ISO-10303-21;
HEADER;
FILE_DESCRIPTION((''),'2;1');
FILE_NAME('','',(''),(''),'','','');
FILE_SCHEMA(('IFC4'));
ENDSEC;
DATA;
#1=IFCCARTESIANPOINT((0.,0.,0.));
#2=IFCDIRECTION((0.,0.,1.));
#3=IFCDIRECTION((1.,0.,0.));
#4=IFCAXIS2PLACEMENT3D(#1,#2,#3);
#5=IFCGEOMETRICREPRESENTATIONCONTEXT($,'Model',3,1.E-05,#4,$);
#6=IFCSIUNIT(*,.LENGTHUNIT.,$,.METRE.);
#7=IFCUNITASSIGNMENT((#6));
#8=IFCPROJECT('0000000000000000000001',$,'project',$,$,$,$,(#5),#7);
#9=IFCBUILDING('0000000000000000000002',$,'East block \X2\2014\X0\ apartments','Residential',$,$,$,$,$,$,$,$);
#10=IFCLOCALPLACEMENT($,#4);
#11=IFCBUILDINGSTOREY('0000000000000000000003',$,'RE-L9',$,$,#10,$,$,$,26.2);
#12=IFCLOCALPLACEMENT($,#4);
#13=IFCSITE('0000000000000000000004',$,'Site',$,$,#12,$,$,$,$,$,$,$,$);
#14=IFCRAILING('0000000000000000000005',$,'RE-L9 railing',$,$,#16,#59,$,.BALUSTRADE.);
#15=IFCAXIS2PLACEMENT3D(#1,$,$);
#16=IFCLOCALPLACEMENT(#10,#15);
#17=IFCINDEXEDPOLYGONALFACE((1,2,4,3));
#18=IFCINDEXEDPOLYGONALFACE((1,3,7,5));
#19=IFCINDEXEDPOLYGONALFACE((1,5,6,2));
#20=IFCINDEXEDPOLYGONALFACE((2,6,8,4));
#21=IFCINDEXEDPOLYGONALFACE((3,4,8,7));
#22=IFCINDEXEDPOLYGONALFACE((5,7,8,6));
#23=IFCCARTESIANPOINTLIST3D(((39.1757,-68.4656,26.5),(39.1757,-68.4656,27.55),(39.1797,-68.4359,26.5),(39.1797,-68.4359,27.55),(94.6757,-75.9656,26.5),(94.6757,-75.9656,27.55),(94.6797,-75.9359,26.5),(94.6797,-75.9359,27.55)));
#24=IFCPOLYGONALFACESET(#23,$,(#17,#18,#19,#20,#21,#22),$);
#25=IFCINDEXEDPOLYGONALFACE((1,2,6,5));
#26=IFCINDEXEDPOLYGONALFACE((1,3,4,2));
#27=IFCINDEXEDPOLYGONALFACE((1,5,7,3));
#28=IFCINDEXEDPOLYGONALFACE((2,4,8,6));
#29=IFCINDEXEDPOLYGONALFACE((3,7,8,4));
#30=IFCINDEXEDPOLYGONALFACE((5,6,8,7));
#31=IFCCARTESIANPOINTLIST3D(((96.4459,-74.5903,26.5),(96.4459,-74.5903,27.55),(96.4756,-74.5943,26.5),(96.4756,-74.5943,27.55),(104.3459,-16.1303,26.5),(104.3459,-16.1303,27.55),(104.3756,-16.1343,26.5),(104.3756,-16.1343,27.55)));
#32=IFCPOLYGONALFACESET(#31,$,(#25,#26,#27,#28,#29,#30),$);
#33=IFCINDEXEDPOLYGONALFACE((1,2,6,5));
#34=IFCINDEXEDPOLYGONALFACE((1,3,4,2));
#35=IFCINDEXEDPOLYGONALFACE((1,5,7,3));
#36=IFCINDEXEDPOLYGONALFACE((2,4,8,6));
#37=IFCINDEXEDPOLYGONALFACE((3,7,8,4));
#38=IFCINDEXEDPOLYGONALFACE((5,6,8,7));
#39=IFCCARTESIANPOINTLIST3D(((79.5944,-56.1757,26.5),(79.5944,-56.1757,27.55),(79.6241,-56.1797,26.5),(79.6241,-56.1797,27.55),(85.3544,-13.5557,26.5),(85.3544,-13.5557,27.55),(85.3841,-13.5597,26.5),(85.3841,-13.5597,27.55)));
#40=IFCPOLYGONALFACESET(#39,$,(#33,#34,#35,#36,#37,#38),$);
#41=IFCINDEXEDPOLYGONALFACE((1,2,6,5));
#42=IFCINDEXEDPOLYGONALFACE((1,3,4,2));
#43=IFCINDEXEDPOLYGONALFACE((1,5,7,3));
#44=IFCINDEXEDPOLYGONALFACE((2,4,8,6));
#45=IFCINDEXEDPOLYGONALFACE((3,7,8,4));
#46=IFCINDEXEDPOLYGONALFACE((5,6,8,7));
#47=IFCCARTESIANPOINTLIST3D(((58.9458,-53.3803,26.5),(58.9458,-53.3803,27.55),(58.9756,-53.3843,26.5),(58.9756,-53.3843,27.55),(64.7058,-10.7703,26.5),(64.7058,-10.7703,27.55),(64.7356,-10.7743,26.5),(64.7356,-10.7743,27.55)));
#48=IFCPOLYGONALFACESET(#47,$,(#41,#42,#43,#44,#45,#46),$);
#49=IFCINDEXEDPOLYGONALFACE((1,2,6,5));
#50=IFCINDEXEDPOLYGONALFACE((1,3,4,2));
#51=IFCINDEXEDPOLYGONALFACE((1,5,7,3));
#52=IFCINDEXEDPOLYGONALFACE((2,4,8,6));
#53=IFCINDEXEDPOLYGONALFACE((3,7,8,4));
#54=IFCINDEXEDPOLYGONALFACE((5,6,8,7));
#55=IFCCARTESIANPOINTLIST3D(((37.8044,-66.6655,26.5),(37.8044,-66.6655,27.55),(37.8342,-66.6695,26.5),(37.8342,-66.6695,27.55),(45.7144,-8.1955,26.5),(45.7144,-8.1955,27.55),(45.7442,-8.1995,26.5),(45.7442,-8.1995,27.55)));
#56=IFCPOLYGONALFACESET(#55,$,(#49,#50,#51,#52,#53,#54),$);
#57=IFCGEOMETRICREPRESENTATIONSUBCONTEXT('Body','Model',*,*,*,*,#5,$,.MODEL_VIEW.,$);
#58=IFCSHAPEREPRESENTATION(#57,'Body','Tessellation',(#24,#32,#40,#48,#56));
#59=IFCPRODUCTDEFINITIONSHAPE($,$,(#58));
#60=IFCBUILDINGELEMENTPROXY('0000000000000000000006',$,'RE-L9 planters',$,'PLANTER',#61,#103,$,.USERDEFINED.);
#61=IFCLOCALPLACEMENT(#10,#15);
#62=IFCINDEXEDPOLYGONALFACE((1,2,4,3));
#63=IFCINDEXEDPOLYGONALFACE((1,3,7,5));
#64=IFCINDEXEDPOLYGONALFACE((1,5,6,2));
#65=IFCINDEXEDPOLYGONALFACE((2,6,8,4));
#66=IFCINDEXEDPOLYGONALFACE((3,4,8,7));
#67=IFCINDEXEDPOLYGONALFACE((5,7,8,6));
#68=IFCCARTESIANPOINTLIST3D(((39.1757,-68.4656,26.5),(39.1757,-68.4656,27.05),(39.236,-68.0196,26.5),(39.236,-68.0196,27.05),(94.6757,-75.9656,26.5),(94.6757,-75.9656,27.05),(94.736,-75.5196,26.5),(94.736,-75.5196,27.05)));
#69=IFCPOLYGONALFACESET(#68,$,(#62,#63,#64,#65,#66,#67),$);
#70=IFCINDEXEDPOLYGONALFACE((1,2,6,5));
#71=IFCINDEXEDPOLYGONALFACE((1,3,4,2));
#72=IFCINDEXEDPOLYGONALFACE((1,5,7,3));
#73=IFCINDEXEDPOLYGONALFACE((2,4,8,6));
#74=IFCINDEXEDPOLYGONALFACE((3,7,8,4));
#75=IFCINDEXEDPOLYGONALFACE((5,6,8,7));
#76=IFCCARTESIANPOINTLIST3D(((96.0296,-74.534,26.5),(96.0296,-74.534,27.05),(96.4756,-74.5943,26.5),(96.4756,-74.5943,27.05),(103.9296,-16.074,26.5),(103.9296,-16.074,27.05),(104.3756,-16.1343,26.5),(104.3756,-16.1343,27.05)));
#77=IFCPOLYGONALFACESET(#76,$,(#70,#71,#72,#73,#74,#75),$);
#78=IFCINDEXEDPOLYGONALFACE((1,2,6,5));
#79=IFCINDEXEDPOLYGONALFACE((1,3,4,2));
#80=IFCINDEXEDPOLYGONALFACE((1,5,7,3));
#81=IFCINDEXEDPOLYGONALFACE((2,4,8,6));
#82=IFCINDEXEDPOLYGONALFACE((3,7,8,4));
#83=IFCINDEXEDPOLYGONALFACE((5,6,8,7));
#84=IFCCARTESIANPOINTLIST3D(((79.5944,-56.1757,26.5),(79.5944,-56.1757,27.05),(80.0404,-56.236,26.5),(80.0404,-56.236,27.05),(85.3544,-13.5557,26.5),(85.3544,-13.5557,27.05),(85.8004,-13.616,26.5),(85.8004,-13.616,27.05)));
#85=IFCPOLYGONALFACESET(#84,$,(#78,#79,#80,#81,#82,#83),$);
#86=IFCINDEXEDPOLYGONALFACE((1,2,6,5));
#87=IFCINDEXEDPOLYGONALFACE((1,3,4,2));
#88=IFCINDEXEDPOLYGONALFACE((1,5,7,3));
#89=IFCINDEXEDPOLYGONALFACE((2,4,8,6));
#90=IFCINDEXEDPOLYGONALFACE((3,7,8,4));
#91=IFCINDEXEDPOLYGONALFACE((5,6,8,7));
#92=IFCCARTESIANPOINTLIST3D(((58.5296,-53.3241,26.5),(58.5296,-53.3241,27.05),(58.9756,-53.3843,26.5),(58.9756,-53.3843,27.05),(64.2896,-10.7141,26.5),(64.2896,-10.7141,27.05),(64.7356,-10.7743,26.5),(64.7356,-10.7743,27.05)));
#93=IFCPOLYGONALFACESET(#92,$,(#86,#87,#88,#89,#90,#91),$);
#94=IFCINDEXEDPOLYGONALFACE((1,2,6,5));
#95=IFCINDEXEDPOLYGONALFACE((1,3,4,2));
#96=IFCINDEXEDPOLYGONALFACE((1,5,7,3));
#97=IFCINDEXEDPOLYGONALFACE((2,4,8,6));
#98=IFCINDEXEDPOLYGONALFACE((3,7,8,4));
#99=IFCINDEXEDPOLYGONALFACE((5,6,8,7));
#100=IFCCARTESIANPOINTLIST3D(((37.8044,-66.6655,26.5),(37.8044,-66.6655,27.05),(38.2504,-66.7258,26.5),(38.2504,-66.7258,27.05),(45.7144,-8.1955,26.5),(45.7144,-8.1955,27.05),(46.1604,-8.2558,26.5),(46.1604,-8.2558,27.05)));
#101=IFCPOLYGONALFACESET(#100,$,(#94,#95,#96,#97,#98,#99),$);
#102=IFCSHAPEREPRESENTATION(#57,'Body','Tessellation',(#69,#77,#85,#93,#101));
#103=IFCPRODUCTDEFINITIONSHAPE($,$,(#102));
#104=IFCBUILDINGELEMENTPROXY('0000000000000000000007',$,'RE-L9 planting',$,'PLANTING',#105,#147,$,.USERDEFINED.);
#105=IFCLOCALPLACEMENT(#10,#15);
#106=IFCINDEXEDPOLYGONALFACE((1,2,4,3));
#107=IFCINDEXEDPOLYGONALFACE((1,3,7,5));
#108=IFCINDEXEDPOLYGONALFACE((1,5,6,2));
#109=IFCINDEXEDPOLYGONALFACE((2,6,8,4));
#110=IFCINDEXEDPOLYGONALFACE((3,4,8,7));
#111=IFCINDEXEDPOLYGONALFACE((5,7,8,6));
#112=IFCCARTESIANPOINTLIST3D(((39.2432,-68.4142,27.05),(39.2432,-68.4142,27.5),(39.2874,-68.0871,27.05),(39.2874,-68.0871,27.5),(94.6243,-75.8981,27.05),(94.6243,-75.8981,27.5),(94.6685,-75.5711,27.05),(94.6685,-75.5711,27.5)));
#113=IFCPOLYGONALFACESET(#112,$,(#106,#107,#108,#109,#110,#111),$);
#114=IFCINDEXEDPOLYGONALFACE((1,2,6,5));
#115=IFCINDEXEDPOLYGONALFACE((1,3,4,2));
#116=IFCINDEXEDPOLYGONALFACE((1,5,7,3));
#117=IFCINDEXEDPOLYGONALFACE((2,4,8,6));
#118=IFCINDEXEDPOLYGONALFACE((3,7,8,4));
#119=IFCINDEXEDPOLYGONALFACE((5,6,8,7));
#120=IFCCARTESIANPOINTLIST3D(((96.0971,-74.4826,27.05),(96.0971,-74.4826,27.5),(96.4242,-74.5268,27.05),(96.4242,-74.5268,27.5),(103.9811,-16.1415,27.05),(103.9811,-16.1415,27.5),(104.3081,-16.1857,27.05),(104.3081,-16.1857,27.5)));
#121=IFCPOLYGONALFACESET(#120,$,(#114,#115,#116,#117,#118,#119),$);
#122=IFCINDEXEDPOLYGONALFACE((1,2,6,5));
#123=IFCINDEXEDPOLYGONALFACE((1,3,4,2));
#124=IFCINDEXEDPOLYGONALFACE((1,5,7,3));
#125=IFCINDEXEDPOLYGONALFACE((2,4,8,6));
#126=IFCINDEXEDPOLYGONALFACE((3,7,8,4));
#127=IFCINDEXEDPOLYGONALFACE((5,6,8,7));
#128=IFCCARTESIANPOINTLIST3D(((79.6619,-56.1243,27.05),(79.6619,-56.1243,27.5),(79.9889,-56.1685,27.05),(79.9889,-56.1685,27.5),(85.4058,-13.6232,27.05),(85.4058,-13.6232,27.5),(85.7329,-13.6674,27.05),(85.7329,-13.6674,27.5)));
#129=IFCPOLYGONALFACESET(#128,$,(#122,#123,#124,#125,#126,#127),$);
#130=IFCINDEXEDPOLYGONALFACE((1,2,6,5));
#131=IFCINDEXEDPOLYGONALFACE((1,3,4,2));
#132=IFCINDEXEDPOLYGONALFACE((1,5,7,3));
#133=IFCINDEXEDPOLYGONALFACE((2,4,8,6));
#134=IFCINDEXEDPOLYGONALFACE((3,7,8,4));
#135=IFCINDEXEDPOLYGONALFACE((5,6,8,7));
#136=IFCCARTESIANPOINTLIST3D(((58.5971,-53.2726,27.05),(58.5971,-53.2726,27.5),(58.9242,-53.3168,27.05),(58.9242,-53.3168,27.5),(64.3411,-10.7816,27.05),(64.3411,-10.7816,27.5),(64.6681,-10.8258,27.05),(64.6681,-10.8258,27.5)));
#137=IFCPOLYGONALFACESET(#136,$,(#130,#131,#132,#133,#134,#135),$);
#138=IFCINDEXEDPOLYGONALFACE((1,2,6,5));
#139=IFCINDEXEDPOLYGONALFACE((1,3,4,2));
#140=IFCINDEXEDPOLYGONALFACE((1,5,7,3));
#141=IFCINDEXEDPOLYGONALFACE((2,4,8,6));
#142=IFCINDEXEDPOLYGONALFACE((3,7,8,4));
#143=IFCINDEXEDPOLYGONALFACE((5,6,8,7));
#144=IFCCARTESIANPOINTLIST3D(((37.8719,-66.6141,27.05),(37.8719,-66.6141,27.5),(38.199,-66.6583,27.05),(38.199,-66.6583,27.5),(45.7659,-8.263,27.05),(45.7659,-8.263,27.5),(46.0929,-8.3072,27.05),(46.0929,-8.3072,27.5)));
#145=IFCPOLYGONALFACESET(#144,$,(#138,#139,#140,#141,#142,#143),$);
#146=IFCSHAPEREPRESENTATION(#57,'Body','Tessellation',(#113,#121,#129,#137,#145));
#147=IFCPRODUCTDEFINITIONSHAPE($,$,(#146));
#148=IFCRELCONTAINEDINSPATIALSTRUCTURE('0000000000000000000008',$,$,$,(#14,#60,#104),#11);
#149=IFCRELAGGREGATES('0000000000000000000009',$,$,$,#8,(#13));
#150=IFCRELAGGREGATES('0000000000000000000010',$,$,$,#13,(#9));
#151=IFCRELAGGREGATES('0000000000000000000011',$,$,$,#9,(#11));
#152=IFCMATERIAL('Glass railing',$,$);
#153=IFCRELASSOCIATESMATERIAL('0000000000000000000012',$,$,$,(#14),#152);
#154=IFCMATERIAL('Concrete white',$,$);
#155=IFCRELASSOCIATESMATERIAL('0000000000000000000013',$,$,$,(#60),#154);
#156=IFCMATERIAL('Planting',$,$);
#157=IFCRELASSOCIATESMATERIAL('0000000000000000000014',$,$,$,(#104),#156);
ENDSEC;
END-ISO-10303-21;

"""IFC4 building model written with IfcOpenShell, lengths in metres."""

from ifc_helpers import new_model, si_unit, frame, origin_with_axes, place, context, subcontext, project, spatial, polyline, outline, extrude, material, element, save


model = new_model("IFC4")

# Units and contexts
model_context = context("Model", 3, precision=1e-05, world=origin_with_axes())
body_context = subcontext(model_context, "Body", "Model", "MODEL_VIEW")
ifc_project = project(units=[si_unit("LENGTHUNIT", "METRE")], contexts=[model_context])

# Site, building, storey
site_placement = place(None, origin_with_axes())
site = spatial("IfcSite", under=ifc_project, at=site_placement, Name="Site")
building = spatial("IfcBuilding", under=site, Name="East block — apartments", Description="Residential")
storey_placement = place(None, origin_with_axes())
storey = spatial("IfcBuildingStorey", under=building, at=storey_placement, Name="RE-L9", Elevation=26.2)

# Railing
ifc_material_1 = material(Name="Glass railing")
railing_placement = place(storey_placement, origin_with_axes())
element("IfcRailing", 1, at=railing_placement, inside=storey, material=ifc_material_1, Name="RE-L9 railing", PredefinedType="BALUSTRADE", context=body_context, shape_type="SweptSolid", body=[
    extrude(outline(polyline([(39.1757, -68.4656), (94.6757, -75.9656), (94.6797, -75.9359), (39.1797, -68.4359), (39.1757, -68.4656)])), frame((0.0, 0.0, 26.5), z_axis=(0.0, 0.0, 1.0), x_axis=(1.0, 0.0, 0.0)), (0.0, 0.0, 1.0), 1.05),
    extrude(outline(polyline([(96.4756, -74.5943), (104.3756, -16.1343), (104.3459, -16.1303), (96.4459, -74.5903), (96.4756, -74.5943)])), frame((0.0, 0.0, 26.5), z_axis=(0.0, 0.0, 1.0), x_axis=(1.0, 0.0, 0.0)), (0.0, 0.0, 1.0), 1.05),
    extrude(outline(polyline([(85.3544, -13.5557), (79.5944, -56.1757), (79.6241, -56.1797), (85.3841, -13.5597), (85.3544, -13.5557)])), frame((0.0, 0.0, 26.5), z_axis=(0.0, 0.0, 1.0), x_axis=(1.0, 0.0, 0.0)), (0.0, 0.0, 1.0), 1.05),
    extrude(outline(polyline([(58.9756, -53.3843), (64.7356, -10.7743), (64.7058, -10.7703), (58.9458, -53.3803), (58.9756, -53.3843)])), frame((0.0, 0.0, 26.5), z_axis=(0.0, 0.0, 1.0), x_axis=(1.0, 0.0, 0.0)), (0.0, 0.0, 1.0), 1.05),
    extrude(outline(polyline([(45.7144, -8.1955), (37.8044, -66.6655), (37.8342, -66.6695), (45.7442, -8.1995), (45.7144, -8.1955)])), frame((0.0, 0.0, 26.5), z_axis=(0.0, 0.0, 1.0), x_axis=(1.0, 0.0, 0.0)), (0.0, 0.0, 1.0), 1.05),
])

# Building element proxies
ifc_material_2 = material(Name="Concrete white")
proxy_1_placement = place(storey_placement, origin_with_axes())
element("IfcBuildingElementProxy", 2, at=proxy_1_placement, inside=storey, material=ifc_material_2, Name="RE-L9 planters", ObjectType="PLANTER", PredefinedType="USERDEFINED", context=body_context, shape_type="SweptSolid", body=[
    extrude(outline(polyline([(39.1757, -68.4656), (94.6757, -75.9656), (94.736, -75.5196), (39.236, -68.0196), (39.1757, -68.4656)])), frame((0.0, 0.0, 26.5), z_axis=(0.0, 0.0, 1.0), x_axis=(1.0, 0.0, 0.0)), (0.0, 0.0, 1.0), 0.55),
    extrude(outline(polyline([(96.4756, -74.5943), (104.3756, -16.1343), (103.9296, -16.074), (96.0296, -74.534), (96.4756, -74.5943)])), frame((0.0, 0.0, 26.5), z_axis=(0.0, 0.0, 1.0), x_axis=(1.0, 0.0, 0.0)), (0.0, 0.0, 1.0), 0.55),
    extrude(outline(polyline([(85.3544, -13.5557), (79.5944, -56.1757), (80.0404, -56.236), (85.8004, -13.616), (85.3544, -13.5557)])), frame((0.0, 0.0, 26.5), z_axis=(0.0, 0.0, 1.0), x_axis=(1.0, 0.0, 0.0)), (0.0, 0.0, 1.0), 0.55),
    extrude(outline(polyline([(58.9756, -53.3843), (64.7356, -10.7743), (64.2896, -10.7141), (58.5296, -53.3241), (58.9756, -53.3843)])), frame((0.0, 0.0, 26.5), z_axis=(0.0, 0.0, 1.0), x_axis=(1.0, 0.0, 0.0)), (0.0, 0.0, 1.0), 0.55),
    extrude(outline(polyline([(45.7144, -8.1955), (37.8044, -66.6655), (38.2504, -66.7258), (46.1604, -8.2558), (45.7144, -8.1955)])), frame((0.0, 0.0, 26.5), z_axis=(0.0, 0.0, 1.0), x_axis=(1.0, 0.0, 0.0)), (0.0, 0.0, 1.0), 0.55),
])
ifc_material_3 = material(Name="Planting")
proxy_2_placement = place(storey_placement, origin_with_axes())
element("IfcBuildingElementProxy", 3, at=proxy_2_placement, inside=storey, material=ifc_material_3, Name="RE-L9 planting", ObjectType="PLANTING", PredefinedType="USERDEFINED", context=body_context, shape_type="SweptSolid", body=[
    extrude(outline(polyline([(39.2432, -68.4142), (94.6243, -75.8981), (94.6685, -75.5711), (39.2874, -68.0871), (39.2432, -68.4142)])), frame((0.0, 0.0, 27.05), z_axis=(0.0, 0.0, 1.0), x_axis=(1.0, 0.0, 0.0)), (0.0, 0.0, 1.0), 0.45),
    extrude(outline(polyline([(96.4242, -74.5268), (104.3081, -16.1857), (103.9811, -16.1415), (96.0971, -74.4826), (96.4242, -74.5268)])), frame((0.0, 0.0, 27.05), z_axis=(0.0, 0.0, 1.0), x_axis=(1.0, 0.0, 0.0)), (0.0, 0.0, 1.0), 0.45),
    extrude(outline(polyline([(85.4058, -13.6232), (79.6619, -56.1243), (79.9889, -56.1685), (85.7329, -13.6674), (85.4058, -13.6232)])), frame((0.0, 0.0, 27.05), z_axis=(0.0, 0.0, 1.0), x_axis=(1.0, 0.0, 0.0)), (0.0, 0.0, 1.0), 0.45),
    extrude(outline(polyline([(58.9242, -53.3168), (64.6681, -10.8258), (64.3411, -10.7816), (58.5971, -53.2726), (58.9242, -53.3168)])), frame((0.0, 0.0, 27.05), z_axis=(0.0, 0.0, 1.0), x_axis=(1.0, 0.0, 0.0)), (0.0, 0.0, 1.0), 0.45),
    extrude(outline(polyline([(45.7659, -8.263), (37.8719, -66.6141), (38.199, -66.6583), (46.0929, -8.3072), (45.7659, -8.263)])), frame((0.0, 0.0, 27.05), z_axis=(0.0, 0.0, 1.0), x_axis=(1.0, 0.0, 0.0)), (0.0, 0.0, 1.0), 0.45),
])

save(model, "model.ifc")
